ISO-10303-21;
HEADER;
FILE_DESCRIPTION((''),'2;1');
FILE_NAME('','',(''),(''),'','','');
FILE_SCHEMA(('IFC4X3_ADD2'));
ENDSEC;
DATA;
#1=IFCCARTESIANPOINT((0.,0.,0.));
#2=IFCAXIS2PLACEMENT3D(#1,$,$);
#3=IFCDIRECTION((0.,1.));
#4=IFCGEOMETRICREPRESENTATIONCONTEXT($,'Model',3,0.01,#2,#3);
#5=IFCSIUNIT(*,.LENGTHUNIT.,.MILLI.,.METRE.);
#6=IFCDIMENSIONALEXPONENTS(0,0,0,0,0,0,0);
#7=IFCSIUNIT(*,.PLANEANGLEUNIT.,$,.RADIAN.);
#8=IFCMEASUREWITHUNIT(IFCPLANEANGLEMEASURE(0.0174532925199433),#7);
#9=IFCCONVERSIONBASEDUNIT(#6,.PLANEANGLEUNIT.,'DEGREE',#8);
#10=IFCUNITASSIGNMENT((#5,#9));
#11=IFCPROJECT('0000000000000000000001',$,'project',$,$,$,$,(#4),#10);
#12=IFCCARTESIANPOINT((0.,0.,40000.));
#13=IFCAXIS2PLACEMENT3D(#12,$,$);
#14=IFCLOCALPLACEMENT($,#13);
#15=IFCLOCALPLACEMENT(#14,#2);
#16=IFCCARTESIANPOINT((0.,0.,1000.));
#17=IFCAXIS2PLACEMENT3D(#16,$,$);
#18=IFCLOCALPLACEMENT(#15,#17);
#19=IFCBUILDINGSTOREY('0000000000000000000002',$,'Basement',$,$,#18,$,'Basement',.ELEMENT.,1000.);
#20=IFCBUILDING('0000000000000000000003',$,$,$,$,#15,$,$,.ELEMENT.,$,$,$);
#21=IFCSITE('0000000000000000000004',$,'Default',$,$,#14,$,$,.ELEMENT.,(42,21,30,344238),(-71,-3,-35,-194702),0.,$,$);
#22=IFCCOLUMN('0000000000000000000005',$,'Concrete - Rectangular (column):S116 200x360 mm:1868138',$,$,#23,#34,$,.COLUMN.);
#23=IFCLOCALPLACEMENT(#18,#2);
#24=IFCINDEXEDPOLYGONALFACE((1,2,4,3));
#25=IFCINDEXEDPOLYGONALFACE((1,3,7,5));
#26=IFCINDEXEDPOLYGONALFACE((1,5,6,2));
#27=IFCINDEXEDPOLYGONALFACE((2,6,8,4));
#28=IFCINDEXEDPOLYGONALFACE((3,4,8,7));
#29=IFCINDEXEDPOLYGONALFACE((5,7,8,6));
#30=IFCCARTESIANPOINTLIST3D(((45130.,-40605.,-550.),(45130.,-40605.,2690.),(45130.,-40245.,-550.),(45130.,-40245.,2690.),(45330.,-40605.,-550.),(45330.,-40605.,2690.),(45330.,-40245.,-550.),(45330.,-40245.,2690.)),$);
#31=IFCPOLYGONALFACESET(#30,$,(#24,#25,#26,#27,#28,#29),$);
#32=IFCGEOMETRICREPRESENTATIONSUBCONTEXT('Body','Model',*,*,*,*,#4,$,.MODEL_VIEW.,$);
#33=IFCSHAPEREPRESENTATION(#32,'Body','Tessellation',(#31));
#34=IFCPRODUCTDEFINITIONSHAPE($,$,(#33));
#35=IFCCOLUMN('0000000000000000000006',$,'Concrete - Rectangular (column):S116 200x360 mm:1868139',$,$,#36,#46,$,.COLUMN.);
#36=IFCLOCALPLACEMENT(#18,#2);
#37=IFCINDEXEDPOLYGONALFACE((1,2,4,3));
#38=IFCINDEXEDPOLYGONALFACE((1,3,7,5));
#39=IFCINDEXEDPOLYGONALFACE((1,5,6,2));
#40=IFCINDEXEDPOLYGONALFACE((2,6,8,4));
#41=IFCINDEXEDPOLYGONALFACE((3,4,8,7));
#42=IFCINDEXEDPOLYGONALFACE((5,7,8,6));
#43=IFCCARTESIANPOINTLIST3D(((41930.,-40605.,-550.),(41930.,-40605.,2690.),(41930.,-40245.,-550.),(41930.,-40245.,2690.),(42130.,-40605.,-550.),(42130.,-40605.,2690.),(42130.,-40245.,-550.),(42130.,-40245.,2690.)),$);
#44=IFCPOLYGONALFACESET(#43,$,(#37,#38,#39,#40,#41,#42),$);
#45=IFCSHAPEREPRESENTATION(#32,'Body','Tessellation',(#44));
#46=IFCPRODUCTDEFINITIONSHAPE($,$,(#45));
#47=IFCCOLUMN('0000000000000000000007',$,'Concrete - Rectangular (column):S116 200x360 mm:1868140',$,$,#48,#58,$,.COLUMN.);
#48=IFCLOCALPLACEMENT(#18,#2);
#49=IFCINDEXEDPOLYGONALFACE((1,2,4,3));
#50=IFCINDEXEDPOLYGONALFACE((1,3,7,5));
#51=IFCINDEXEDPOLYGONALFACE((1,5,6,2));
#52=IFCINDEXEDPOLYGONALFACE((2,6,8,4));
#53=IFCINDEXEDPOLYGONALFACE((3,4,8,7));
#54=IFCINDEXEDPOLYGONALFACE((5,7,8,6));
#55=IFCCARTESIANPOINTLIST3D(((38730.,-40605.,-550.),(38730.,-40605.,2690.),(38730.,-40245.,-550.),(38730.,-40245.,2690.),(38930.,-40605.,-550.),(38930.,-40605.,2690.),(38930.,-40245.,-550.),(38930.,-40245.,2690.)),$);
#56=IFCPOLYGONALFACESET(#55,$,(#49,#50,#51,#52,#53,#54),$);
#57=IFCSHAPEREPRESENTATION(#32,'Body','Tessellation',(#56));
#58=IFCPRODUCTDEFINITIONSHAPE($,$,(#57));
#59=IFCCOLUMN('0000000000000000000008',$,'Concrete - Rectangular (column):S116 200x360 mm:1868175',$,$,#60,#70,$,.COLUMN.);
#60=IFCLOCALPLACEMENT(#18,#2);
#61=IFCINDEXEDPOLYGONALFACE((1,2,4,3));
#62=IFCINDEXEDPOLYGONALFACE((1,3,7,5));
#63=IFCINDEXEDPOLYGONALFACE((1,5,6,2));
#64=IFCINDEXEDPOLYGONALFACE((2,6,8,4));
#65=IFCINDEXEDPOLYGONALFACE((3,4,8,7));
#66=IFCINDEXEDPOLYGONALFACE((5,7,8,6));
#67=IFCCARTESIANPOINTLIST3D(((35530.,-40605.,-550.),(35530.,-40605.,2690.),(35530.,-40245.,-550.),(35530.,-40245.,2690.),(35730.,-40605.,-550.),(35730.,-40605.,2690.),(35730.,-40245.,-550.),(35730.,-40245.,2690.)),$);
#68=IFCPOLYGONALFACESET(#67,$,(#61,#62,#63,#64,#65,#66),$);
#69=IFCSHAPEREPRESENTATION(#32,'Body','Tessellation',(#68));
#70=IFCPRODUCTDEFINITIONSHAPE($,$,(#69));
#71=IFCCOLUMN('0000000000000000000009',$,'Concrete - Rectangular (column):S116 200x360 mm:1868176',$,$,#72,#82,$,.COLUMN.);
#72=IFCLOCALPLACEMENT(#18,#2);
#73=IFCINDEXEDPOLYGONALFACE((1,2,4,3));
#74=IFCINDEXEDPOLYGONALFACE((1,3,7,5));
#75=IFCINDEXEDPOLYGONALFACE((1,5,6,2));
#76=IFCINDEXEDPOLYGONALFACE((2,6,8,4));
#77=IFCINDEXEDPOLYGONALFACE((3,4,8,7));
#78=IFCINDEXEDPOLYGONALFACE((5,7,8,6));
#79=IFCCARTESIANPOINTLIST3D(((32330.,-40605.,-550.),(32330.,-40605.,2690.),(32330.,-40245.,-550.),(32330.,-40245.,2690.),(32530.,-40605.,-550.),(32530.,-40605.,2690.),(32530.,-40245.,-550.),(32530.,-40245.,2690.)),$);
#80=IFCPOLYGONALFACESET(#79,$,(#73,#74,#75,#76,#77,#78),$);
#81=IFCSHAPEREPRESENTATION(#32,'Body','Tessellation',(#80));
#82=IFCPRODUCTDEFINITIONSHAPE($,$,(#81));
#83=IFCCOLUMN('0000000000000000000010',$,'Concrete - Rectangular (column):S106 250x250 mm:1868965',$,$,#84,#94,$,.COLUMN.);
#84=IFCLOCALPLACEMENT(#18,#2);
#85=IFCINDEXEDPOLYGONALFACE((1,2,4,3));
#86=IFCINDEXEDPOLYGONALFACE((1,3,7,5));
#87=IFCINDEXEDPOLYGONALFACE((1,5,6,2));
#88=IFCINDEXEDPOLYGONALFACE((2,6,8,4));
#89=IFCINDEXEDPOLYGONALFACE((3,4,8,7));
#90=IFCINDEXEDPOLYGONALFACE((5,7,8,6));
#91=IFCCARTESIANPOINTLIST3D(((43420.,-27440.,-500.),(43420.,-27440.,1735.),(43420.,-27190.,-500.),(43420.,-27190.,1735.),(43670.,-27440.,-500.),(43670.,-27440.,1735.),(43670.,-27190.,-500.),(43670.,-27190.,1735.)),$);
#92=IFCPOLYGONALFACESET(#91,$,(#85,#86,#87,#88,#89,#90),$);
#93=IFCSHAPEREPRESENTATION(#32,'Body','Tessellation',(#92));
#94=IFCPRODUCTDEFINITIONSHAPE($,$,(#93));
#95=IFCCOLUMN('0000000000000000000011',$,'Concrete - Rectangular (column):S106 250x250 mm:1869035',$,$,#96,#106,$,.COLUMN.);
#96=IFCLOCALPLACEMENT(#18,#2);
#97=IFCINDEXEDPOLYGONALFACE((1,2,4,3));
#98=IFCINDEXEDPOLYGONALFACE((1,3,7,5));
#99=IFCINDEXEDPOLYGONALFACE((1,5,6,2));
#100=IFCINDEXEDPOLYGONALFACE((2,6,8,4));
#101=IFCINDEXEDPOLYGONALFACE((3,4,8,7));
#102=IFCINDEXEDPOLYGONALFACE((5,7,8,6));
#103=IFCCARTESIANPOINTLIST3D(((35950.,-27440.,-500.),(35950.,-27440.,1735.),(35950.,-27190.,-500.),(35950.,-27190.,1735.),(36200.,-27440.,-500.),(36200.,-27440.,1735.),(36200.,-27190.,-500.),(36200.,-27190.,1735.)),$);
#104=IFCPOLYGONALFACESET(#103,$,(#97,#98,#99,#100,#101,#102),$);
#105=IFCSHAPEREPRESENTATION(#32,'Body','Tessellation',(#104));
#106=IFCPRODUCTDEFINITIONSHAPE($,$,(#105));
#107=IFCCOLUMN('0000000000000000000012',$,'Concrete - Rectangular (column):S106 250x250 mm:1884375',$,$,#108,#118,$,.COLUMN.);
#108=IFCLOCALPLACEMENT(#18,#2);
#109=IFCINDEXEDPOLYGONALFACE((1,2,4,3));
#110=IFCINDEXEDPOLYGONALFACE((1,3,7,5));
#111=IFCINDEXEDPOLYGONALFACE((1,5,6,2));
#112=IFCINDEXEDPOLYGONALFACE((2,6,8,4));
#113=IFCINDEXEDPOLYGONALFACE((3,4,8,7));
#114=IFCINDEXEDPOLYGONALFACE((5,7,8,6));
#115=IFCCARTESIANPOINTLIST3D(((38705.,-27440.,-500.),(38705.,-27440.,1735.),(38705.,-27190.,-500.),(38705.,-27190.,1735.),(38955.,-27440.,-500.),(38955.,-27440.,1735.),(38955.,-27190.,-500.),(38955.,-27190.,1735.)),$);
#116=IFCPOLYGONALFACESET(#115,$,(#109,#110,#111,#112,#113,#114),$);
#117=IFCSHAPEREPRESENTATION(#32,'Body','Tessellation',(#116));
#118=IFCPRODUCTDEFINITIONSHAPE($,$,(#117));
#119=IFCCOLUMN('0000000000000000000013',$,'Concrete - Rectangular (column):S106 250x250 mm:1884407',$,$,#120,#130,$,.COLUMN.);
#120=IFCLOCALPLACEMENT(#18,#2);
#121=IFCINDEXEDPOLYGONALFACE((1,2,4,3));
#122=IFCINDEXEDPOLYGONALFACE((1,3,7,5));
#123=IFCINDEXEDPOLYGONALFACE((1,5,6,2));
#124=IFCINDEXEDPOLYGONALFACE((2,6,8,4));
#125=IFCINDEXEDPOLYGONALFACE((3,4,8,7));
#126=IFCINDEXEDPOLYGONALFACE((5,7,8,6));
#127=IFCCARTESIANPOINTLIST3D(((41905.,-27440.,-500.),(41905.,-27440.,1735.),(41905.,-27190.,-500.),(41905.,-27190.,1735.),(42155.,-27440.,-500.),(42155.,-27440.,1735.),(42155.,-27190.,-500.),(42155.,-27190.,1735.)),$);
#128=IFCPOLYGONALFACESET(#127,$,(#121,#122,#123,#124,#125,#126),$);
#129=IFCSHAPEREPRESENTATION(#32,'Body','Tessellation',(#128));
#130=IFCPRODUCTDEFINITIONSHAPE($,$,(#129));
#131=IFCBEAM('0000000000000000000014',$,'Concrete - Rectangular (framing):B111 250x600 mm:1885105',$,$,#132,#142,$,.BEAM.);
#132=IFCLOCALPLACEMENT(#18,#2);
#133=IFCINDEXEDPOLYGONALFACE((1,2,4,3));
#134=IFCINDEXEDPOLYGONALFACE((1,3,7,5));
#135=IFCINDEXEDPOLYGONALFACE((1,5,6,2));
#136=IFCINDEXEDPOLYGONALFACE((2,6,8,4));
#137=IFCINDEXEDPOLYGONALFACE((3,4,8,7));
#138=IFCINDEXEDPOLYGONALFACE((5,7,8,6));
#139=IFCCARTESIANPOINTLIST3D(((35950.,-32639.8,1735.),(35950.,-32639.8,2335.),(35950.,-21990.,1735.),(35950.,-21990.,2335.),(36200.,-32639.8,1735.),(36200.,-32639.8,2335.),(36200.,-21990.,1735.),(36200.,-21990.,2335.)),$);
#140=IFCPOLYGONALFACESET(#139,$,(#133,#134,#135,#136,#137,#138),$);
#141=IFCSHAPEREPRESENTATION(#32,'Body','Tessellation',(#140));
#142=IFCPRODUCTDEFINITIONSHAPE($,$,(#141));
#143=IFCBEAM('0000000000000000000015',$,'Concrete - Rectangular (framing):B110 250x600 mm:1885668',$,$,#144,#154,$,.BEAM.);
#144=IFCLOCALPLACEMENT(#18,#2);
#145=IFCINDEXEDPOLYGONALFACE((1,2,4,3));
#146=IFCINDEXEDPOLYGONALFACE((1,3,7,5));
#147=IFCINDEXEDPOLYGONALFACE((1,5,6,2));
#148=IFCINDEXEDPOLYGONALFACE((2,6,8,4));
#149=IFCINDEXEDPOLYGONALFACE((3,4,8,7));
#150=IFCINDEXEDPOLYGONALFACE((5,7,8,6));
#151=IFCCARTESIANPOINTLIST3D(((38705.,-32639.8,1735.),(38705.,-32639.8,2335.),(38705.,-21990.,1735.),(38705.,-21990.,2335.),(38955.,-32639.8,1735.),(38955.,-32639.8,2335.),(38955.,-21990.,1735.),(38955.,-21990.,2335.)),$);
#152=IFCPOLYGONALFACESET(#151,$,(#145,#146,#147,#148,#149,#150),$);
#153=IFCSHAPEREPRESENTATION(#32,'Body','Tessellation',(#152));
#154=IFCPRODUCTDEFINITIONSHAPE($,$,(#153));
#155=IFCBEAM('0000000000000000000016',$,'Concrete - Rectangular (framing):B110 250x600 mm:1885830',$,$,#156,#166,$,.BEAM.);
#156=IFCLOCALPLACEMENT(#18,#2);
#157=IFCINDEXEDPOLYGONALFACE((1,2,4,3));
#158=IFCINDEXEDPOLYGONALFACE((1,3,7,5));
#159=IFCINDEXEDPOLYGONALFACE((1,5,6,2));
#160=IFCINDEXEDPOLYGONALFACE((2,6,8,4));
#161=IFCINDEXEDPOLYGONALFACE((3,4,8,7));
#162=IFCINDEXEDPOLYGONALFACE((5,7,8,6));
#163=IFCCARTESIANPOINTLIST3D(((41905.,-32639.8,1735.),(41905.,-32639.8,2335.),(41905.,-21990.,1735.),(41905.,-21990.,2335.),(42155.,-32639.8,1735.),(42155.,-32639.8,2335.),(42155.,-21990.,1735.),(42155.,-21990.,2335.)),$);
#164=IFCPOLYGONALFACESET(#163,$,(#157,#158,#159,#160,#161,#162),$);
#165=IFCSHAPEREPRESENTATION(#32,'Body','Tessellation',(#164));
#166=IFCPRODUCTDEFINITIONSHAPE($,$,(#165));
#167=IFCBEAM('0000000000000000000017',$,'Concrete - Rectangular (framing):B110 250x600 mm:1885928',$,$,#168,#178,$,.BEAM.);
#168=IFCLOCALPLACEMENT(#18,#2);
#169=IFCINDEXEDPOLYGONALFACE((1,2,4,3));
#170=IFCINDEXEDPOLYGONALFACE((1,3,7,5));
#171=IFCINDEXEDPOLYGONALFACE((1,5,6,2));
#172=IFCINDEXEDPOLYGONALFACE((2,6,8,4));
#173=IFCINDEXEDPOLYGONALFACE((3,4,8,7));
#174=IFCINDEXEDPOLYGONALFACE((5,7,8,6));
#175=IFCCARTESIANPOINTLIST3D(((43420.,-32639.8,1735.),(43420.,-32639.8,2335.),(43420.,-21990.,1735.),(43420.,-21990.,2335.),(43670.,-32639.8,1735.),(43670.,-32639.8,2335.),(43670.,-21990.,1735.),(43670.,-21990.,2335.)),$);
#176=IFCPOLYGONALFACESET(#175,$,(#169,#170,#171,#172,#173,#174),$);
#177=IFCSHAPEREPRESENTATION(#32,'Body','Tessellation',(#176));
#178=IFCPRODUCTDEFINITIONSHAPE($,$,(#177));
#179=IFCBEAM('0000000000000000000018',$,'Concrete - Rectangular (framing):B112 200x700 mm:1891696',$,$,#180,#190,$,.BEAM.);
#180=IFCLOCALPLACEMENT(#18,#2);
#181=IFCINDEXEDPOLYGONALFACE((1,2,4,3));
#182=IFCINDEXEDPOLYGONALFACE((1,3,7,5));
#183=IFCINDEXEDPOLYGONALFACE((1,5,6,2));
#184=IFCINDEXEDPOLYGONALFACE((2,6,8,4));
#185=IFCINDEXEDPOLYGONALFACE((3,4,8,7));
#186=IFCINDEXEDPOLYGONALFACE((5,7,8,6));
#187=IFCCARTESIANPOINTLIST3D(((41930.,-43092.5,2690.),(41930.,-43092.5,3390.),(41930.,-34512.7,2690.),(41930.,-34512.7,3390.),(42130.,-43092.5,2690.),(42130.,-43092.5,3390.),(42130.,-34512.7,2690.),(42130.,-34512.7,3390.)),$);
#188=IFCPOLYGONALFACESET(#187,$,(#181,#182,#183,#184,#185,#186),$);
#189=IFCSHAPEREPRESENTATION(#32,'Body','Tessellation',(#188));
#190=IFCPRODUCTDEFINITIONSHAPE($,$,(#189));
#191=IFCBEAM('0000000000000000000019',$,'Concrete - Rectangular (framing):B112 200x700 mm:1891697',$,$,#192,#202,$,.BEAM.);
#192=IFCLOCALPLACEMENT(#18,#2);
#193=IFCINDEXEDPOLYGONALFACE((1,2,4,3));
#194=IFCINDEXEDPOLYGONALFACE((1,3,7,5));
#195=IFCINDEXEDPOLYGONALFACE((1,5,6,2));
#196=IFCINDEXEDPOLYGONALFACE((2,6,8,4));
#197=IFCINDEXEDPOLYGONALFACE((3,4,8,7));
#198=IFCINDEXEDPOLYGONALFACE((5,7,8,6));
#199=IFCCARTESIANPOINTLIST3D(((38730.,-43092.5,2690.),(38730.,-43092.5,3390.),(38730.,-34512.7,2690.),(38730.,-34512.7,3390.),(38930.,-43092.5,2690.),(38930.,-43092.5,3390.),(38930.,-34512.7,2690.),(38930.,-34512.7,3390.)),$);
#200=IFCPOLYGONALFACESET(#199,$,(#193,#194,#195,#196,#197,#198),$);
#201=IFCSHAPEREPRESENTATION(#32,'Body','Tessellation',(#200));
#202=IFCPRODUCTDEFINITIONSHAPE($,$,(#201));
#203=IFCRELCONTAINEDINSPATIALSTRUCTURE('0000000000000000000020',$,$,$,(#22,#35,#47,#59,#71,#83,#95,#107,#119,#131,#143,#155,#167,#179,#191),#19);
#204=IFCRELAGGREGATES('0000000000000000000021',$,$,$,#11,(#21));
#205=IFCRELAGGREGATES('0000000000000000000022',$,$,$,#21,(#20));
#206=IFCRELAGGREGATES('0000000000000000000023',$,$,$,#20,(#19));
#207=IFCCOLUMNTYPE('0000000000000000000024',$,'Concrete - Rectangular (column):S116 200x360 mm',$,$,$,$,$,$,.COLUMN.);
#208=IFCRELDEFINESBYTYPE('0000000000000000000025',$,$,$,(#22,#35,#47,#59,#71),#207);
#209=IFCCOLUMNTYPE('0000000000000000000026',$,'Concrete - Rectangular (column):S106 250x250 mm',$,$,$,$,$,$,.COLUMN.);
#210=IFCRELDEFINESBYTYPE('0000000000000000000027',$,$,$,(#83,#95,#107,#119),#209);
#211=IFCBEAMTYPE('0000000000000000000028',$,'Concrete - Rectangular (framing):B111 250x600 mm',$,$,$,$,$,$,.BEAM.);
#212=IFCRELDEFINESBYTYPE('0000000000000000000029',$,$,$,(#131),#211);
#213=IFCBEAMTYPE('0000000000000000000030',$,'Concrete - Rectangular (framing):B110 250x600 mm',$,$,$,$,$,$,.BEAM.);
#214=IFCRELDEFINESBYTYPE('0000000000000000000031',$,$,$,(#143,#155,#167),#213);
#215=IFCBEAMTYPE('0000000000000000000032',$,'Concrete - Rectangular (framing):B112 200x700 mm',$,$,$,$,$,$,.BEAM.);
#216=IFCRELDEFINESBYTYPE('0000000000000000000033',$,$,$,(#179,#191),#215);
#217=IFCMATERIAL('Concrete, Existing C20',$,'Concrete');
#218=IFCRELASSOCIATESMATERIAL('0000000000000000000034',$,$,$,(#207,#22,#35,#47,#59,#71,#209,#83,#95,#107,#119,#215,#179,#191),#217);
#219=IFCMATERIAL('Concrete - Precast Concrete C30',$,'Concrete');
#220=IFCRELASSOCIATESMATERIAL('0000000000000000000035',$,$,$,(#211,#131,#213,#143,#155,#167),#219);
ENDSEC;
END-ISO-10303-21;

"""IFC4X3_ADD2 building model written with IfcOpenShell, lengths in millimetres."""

from ifc_helpers import new_model, entity, si_unit, converted_unit, direction, frame, frame_2d, origin, origin_2d_with_axis, place, context, subcontext, project, spatial, rectangle, extrude, source, transform, mapped, material, material_profile, profile_set, profile_usage, type_object, type_shapes, element, save


model = new_model("IFC4X3_ADD2")

# Units and contexts
model_context = context("Model", 3, precision=0.01, world=origin(), true_north=direction((0.0, 1.0)))
body_context = subcontext(model_context, "Body", "Model", "MODEL_VIEW")
ifc_project = project(units=[si_unit("LENGTHUNIT", "METRE", prefix="MILLI"), converted_unit("PLANEANGLEUNIT", "DEGREE", entity("IfcPlaneAngleMeasure", 0.0174532925199433), si_unit("PLANEANGLEUNIT", "RADIAN"), dimensions=[0, 0, 0, 0, 0, 0, 0])], contexts=[model_context])

# Site, building, storey
site_placement = place(None, frame((0.0, 0.0, 40000.0)))
site = spatial("IfcSite", under=ifc_project, at=site_placement, Name="Default", CompositionType="ELEMENT", RefLatitude=(42, 21, 30, 344238), RefLongitude=(-71, -3, -35, -194702), RefElevation=0.0)
building_placement = place(site_placement, origin())
building = spatial("IfcBuilding", under=site, at=building_placement, CompositionType="ELEMENT")
storey_placement = place(building_placement, frame((0.0, 0.0, 1000.0)))
storey = spatial("IfcBuildingStorey", under=building, at=storey_placement, Name="Basement", LongName="Basement", CompositionType="ELEMENT", Elevation=1000.0)

# Columns
ifc_material_1 = material(Name="Concrete, Existing C20", Category="Concrete")
ifc_material_profile_1 = material_profile(ifc_material_1, rectangle(XDim=360.0, YDim=200.0, at=origin_2d_with_axis()), Name="S116 200x360 mm")
ifc_profile_set_1 = profile_set([ifc_material_profile_1], Name="S116 200x360 mm")
ifc_profile_usage_1 = profile_usage(ifc_profile_set_1)
column_type_1 = type_object("IfcColumnType", Name="Concrete - Rectangular (column):S116 200x360 mm", PredefinedType="COLUMN", material=ifc_profile_set_1)
shared_shape_1 = source(origin(), body_context, "Body", "SweptSolid", [
    extrude(rectangle(XDim=360.0, YDim=200.0, at=origin_2d_with_axis()), frame((0.0, 0.0, 450.0), z_axis=(0.0, 0.0, 1.0), x_axis=(-1.0, 0.0, 0.0)), (0.0, 0.0, 1.0), 3240.0),
])
type_shapes(column_type_1, [shared_shape_1])
for number, where, z_axis, x_axis, name in (
    (1, (45230.0, -40425.0, -1000.0), (0.0, 0.0, 1.0), (0.0, -1.0, 0.0), "Concrete - Rectangular (column):S116 200x360 mm:1868138"),
    (2, (42030.0, -40425.0, -1000.0), (0.0, 0.0, 1.0), (0.0, -1.0, 0.0), "Concrete - Rectangular (column):S116 200x360 mm:1868139"),
    (3, (38830.0, -40425.0, -1000.0), (0.0, 0.0, 1.0), (0.0, -1.0, 0.0), "Concrete - Rectangular (column):S116 200x360 mm:1868140"),
    (4, (35630.0, -40425.0, -1000.0), (0.0, 0.0, 1.0), (0.0, -1.0, 0.0), "Concrete - Rectangular (column):S116 200x360 mm:1868175"),
    (5, (32430.0, -40425.0, -1000.0), (0.0, 0.0, 1.0), (0.0, -1.0, 0.0), "Concrete - Rectangular (column):S116 200x360 mm:1868176"),
):
    element("IfcColumn", number, at=place(storey_placement, frame(where, z_axis=z_axis, x_axis=x_axis)), inside=storey, type_object=column_type_1, material=ifc_profile_usage_1, Name=name, PredefinedType="COLUMN", context=body_context, shape_type="MappedRepresentation", body=[
        mapped(shared_shape_1, transform((0.0, 0.0, 0.0), scale=1.0)),
    ])
ifc_material_profile_2 = material_profile(ifc_material_1, rectangle(XDim=250.0, YDim=250.0, at=frame_2d((0.0, 0.0), x_axis=(1.0, 0.0))), Name="S106 250x250 mm")
ifc_profile_set_2 = profile_set([ifc_material_profile_2], Name="S106 250x250 mm")
ifc_profile_usage_2 = profile_usage(ifc_profile_set_2)
column_type_2 = type_object("IfcColumnType", Name="Concrete - Rectangular (column):S106 250x250 mm", PredefinedType="COLUMN", material=ifc_profile_set_2)
shared_shape_2 = source(origin(), body_context, "Body", "SweptSolid", [
    extrude(rectangle(XDim=250.0, YDim=250.0, at=origin_2d_with_axis()), frame((0.0, 0.0, 500.0), z_axis=(0.0, 0.0, 1.0), x_axis=(-1.0, 0.0, 0.0)), (0.0, 0.0, 1.0), 2235.0),
])
type_shapes(column_type_2, [shared_shape_2])
for number, where, z_axis, x_axis, name in (
    (6, (43545.0, -27315.0, -1000.0), (0.0, 0.0, 1.0), (0.0, -1.0, 0.0), "Concrete - Rectangular (column):S106 250x250 mm:1868965"),
    (7, (36075.0, -27315.0, -1000.0), (0.0, 0.0, 1.0), (0.0, -1.0, 0.0), "Concrete - Rectangular (column):S106 250x250 mm:1869035"),
    (8, (38830.0, -27315.0, -1000.0), (0.0, 0.0, 1.0), (0.0, -1.0, 0.0), "Concrete - Rectangular (column):S106 250x250 mm:1884375"),
    (9, (42030.0, -27315.0, -1000.0), (0.0, 0.0, 1.0), (0.0, -1.0, 0.0), "Concrete - Rectangular (column):S106 250x250 mm:1884407"),
):
    element("IfcColumn", number, at=place(storey_placement, frame(where, z_axis=z_axis, x_axis=x_axis)), inside=storey, type_object=column_type_2, material=ifc_profile_usage_2, Name=name, PredefinedType="COLUMN", context=body_context, shape_type="MappedRepresentation", body=[
        mapped(shared_shape_2, transform((0.0, 0.0, 0.0), scale=1.0)),
    ])

# Beams
ifc_material_2 = material(Name="Concrete - Precast Concrete C30", Category="Concrete")
ifc_material_profile_3 = material_profile(ifc_material_2, rectangle(XDim=10649.8, YDim=250.0, at=origin_2d_with_axis()), Name="B111 250x600 mm")
ifc_profile_set_3 = profile_set([ifc_material_profile_3], Name="B111 250x600 mm")
ifc_profile_usage_3 = profile_usage(ifc_profile_set_3, cardinal=8)
beam_type_1 = type_object("IfcBeamType", Name="Concrete - Rectangular (framing):B111 250x600 mm", PredefinedType="BEAM", material=ifc_profile_set_3)
shared_shape_3 = source(origin(), body_context, "Body", "SweptSolid", [
    extrude(rectangle(XDim=10649.8, YDim=250.0, at=origin_2d_with_axis()), frame((-10.1, 0.0, -300.0), z_axis=(0.0, 0.0, 1.0), x_axis=(-1.0, 0.0, 0.0)), (0.0, 0.0, 1.0), 600.0),
])
type_shapes(beam_type_1, [shared_shape_3])
beam_1_placement = place(storey_placement, frame((36075.0, -27325.0, 2035.0), z_axis=(0.0, 0.0, 1.0), x_axis=(0.0, -1.0, 0.0)))
element("IfcBeam", 10, at=beam_1_placement, inside=storey, type_object=beam_type_1, material=ifc_profile_usage_3, Name="Concrete - Rectangular (framing):B111 250x600 mm:1885105", PredefinedType="BEAM", context=body_context, shape_type="MappedRepresentation", body=[
    mapped(shared_shape_3, transform((0.0, 0.0, 0.0), scale=1.0)),
])
ifc_material_profile_4 = material_profile(ifc_material_2, rectangle(XDim=10649.8, YDim=250.0, at=origin_2d_with_axis()), Name="B110 250x600 mm")
ifc_profile_set_4 = profile_set([ifc_material_profile_4], Name="B110 250x600 mm")
ifc_profile_usage_4 = profile_usage(ifc_profile_set_4, cardinal=8)
beam_type_2 = type_object("IfcBeamType", Name="Concrete - Rectangular (framing):B110 250x600 mm", PredefinedType="BEAM", material=ifc_profile_set_4)
shared_shape_4 = source(origin(), body_context, "Body", "SweptSolid", [
    extrude(rectangle(XDim=10649.8, YDim=250.0, at=origin_2d_with_axis()), frame((-10.1, 0.0, -300.0), z_axis=(0.0, 0.0, 1.0), x_axis=(-1.0, 0.0, 0.0)), (0.0, 0.0, 1.0), 600.0),
])
type_shapes(beam_type_2, [shared_shape_4])
for number, where, z_axis, x_axis, name in (
    (11, (38830.0, -27325.0, 2035.0), (0.0, 0.0, 1.0), (0.0, -1.0, 0.0), "Concrete - Rectangular (framing):B110 250x600 mm:1885668"),
    (12, (42030.0, -27325.0, 2035.0), (0.0, 0.0, 1.0), (0.0, -1.0, 0.0), "Concrete - Rectangular (framing):B110 250x600 mm:1885830"),
    (13, (43545.0, -27325.0, 2035.0), (0.0, 0.0, 1.0), (0.0, -1.0, 0.0), "Concrete - Rectangular (framing):B110 250x600 mm:1885928"),
):
    element("IfcBeam", number, at=place(storey_placement, frame(where, z_axis=z_axis, x_axis=x_axis)), inside=storey, type_object=beam_type_2, material=ifc_profile_usage_4, Name=name, PredefinedType="BEAM", context=body_context, shape_type="MappedRepresentation", body=[
        mapped(shared_shape_4, transform((0.0, 0.0, 0.0), scale=1.0)),
    ])
ifc_material_profile_5 = material_profile(ifc_material_1, rectangle(XDim=8579.8, YDim=200.0, at=origin_2d_with_axis()), Name="B112 200x700 mm")
ifc_profile_set_5 = profile_set([ifc_material_profile_5], Name="B112 200x700 mm")
ifc_profile_usage_5 = profile_usage(ifc_profile_set_5, cardinal=8)
beam_type_3 = type_object("IfcBeamType", Name="Concrete - Rectangular (framing):B112 200x700 mm", PredefinedType="BEAM", material=ifc_profile_set_5)
shared_shape_5 = source(origin(), body_context, "Body", "SweptSolid", [
    extrude(rectangle(XDim=8579.8, YDim=200.0, at=origin_2d_with_axis()), frame((72.6, 0.0, -350.0), z_axis=(0.0, 0.0, 1.0), x_axis=(-1.0, 0.0, 0.0)), (0.0, 0.0, 1.0), 700.0),
])
type_shapes(beam_type_3, [shared_shape_5])
for number, where, z_axis, x_axis, name in (
    (14, (42030.0, -38730.0, 3040.0), (0.0, 0.0, 1.0), (0.0, -1.0, 0.0), "Concrete - Rectangular (framing):B112 200x700 mm:1891696"),
    (15, (38830.0, -38730.0, 3040.0), (0.0, 0.0, 1.0), (0.0, -1.0, 0.0), "Concrete - Rectangular (framing):B112 200x700 mm:1891697"),
):
    element("IfcBeam", number, at=place(storey_placement, frame(where, z_axis=z_axis, x_axis=x_axis)), inside=storey, type_object=beam_type_3, material=ifc_profile_usage_5, Name=name, PredefinedType="BEAM", context=body_context, shape_type="MappedRepresentation", body=[
        mapped(shared_shape_5, transform((0.0, 0.0, 0.0), scale=1.0)),
    ])

save(model, "model.ifc")
